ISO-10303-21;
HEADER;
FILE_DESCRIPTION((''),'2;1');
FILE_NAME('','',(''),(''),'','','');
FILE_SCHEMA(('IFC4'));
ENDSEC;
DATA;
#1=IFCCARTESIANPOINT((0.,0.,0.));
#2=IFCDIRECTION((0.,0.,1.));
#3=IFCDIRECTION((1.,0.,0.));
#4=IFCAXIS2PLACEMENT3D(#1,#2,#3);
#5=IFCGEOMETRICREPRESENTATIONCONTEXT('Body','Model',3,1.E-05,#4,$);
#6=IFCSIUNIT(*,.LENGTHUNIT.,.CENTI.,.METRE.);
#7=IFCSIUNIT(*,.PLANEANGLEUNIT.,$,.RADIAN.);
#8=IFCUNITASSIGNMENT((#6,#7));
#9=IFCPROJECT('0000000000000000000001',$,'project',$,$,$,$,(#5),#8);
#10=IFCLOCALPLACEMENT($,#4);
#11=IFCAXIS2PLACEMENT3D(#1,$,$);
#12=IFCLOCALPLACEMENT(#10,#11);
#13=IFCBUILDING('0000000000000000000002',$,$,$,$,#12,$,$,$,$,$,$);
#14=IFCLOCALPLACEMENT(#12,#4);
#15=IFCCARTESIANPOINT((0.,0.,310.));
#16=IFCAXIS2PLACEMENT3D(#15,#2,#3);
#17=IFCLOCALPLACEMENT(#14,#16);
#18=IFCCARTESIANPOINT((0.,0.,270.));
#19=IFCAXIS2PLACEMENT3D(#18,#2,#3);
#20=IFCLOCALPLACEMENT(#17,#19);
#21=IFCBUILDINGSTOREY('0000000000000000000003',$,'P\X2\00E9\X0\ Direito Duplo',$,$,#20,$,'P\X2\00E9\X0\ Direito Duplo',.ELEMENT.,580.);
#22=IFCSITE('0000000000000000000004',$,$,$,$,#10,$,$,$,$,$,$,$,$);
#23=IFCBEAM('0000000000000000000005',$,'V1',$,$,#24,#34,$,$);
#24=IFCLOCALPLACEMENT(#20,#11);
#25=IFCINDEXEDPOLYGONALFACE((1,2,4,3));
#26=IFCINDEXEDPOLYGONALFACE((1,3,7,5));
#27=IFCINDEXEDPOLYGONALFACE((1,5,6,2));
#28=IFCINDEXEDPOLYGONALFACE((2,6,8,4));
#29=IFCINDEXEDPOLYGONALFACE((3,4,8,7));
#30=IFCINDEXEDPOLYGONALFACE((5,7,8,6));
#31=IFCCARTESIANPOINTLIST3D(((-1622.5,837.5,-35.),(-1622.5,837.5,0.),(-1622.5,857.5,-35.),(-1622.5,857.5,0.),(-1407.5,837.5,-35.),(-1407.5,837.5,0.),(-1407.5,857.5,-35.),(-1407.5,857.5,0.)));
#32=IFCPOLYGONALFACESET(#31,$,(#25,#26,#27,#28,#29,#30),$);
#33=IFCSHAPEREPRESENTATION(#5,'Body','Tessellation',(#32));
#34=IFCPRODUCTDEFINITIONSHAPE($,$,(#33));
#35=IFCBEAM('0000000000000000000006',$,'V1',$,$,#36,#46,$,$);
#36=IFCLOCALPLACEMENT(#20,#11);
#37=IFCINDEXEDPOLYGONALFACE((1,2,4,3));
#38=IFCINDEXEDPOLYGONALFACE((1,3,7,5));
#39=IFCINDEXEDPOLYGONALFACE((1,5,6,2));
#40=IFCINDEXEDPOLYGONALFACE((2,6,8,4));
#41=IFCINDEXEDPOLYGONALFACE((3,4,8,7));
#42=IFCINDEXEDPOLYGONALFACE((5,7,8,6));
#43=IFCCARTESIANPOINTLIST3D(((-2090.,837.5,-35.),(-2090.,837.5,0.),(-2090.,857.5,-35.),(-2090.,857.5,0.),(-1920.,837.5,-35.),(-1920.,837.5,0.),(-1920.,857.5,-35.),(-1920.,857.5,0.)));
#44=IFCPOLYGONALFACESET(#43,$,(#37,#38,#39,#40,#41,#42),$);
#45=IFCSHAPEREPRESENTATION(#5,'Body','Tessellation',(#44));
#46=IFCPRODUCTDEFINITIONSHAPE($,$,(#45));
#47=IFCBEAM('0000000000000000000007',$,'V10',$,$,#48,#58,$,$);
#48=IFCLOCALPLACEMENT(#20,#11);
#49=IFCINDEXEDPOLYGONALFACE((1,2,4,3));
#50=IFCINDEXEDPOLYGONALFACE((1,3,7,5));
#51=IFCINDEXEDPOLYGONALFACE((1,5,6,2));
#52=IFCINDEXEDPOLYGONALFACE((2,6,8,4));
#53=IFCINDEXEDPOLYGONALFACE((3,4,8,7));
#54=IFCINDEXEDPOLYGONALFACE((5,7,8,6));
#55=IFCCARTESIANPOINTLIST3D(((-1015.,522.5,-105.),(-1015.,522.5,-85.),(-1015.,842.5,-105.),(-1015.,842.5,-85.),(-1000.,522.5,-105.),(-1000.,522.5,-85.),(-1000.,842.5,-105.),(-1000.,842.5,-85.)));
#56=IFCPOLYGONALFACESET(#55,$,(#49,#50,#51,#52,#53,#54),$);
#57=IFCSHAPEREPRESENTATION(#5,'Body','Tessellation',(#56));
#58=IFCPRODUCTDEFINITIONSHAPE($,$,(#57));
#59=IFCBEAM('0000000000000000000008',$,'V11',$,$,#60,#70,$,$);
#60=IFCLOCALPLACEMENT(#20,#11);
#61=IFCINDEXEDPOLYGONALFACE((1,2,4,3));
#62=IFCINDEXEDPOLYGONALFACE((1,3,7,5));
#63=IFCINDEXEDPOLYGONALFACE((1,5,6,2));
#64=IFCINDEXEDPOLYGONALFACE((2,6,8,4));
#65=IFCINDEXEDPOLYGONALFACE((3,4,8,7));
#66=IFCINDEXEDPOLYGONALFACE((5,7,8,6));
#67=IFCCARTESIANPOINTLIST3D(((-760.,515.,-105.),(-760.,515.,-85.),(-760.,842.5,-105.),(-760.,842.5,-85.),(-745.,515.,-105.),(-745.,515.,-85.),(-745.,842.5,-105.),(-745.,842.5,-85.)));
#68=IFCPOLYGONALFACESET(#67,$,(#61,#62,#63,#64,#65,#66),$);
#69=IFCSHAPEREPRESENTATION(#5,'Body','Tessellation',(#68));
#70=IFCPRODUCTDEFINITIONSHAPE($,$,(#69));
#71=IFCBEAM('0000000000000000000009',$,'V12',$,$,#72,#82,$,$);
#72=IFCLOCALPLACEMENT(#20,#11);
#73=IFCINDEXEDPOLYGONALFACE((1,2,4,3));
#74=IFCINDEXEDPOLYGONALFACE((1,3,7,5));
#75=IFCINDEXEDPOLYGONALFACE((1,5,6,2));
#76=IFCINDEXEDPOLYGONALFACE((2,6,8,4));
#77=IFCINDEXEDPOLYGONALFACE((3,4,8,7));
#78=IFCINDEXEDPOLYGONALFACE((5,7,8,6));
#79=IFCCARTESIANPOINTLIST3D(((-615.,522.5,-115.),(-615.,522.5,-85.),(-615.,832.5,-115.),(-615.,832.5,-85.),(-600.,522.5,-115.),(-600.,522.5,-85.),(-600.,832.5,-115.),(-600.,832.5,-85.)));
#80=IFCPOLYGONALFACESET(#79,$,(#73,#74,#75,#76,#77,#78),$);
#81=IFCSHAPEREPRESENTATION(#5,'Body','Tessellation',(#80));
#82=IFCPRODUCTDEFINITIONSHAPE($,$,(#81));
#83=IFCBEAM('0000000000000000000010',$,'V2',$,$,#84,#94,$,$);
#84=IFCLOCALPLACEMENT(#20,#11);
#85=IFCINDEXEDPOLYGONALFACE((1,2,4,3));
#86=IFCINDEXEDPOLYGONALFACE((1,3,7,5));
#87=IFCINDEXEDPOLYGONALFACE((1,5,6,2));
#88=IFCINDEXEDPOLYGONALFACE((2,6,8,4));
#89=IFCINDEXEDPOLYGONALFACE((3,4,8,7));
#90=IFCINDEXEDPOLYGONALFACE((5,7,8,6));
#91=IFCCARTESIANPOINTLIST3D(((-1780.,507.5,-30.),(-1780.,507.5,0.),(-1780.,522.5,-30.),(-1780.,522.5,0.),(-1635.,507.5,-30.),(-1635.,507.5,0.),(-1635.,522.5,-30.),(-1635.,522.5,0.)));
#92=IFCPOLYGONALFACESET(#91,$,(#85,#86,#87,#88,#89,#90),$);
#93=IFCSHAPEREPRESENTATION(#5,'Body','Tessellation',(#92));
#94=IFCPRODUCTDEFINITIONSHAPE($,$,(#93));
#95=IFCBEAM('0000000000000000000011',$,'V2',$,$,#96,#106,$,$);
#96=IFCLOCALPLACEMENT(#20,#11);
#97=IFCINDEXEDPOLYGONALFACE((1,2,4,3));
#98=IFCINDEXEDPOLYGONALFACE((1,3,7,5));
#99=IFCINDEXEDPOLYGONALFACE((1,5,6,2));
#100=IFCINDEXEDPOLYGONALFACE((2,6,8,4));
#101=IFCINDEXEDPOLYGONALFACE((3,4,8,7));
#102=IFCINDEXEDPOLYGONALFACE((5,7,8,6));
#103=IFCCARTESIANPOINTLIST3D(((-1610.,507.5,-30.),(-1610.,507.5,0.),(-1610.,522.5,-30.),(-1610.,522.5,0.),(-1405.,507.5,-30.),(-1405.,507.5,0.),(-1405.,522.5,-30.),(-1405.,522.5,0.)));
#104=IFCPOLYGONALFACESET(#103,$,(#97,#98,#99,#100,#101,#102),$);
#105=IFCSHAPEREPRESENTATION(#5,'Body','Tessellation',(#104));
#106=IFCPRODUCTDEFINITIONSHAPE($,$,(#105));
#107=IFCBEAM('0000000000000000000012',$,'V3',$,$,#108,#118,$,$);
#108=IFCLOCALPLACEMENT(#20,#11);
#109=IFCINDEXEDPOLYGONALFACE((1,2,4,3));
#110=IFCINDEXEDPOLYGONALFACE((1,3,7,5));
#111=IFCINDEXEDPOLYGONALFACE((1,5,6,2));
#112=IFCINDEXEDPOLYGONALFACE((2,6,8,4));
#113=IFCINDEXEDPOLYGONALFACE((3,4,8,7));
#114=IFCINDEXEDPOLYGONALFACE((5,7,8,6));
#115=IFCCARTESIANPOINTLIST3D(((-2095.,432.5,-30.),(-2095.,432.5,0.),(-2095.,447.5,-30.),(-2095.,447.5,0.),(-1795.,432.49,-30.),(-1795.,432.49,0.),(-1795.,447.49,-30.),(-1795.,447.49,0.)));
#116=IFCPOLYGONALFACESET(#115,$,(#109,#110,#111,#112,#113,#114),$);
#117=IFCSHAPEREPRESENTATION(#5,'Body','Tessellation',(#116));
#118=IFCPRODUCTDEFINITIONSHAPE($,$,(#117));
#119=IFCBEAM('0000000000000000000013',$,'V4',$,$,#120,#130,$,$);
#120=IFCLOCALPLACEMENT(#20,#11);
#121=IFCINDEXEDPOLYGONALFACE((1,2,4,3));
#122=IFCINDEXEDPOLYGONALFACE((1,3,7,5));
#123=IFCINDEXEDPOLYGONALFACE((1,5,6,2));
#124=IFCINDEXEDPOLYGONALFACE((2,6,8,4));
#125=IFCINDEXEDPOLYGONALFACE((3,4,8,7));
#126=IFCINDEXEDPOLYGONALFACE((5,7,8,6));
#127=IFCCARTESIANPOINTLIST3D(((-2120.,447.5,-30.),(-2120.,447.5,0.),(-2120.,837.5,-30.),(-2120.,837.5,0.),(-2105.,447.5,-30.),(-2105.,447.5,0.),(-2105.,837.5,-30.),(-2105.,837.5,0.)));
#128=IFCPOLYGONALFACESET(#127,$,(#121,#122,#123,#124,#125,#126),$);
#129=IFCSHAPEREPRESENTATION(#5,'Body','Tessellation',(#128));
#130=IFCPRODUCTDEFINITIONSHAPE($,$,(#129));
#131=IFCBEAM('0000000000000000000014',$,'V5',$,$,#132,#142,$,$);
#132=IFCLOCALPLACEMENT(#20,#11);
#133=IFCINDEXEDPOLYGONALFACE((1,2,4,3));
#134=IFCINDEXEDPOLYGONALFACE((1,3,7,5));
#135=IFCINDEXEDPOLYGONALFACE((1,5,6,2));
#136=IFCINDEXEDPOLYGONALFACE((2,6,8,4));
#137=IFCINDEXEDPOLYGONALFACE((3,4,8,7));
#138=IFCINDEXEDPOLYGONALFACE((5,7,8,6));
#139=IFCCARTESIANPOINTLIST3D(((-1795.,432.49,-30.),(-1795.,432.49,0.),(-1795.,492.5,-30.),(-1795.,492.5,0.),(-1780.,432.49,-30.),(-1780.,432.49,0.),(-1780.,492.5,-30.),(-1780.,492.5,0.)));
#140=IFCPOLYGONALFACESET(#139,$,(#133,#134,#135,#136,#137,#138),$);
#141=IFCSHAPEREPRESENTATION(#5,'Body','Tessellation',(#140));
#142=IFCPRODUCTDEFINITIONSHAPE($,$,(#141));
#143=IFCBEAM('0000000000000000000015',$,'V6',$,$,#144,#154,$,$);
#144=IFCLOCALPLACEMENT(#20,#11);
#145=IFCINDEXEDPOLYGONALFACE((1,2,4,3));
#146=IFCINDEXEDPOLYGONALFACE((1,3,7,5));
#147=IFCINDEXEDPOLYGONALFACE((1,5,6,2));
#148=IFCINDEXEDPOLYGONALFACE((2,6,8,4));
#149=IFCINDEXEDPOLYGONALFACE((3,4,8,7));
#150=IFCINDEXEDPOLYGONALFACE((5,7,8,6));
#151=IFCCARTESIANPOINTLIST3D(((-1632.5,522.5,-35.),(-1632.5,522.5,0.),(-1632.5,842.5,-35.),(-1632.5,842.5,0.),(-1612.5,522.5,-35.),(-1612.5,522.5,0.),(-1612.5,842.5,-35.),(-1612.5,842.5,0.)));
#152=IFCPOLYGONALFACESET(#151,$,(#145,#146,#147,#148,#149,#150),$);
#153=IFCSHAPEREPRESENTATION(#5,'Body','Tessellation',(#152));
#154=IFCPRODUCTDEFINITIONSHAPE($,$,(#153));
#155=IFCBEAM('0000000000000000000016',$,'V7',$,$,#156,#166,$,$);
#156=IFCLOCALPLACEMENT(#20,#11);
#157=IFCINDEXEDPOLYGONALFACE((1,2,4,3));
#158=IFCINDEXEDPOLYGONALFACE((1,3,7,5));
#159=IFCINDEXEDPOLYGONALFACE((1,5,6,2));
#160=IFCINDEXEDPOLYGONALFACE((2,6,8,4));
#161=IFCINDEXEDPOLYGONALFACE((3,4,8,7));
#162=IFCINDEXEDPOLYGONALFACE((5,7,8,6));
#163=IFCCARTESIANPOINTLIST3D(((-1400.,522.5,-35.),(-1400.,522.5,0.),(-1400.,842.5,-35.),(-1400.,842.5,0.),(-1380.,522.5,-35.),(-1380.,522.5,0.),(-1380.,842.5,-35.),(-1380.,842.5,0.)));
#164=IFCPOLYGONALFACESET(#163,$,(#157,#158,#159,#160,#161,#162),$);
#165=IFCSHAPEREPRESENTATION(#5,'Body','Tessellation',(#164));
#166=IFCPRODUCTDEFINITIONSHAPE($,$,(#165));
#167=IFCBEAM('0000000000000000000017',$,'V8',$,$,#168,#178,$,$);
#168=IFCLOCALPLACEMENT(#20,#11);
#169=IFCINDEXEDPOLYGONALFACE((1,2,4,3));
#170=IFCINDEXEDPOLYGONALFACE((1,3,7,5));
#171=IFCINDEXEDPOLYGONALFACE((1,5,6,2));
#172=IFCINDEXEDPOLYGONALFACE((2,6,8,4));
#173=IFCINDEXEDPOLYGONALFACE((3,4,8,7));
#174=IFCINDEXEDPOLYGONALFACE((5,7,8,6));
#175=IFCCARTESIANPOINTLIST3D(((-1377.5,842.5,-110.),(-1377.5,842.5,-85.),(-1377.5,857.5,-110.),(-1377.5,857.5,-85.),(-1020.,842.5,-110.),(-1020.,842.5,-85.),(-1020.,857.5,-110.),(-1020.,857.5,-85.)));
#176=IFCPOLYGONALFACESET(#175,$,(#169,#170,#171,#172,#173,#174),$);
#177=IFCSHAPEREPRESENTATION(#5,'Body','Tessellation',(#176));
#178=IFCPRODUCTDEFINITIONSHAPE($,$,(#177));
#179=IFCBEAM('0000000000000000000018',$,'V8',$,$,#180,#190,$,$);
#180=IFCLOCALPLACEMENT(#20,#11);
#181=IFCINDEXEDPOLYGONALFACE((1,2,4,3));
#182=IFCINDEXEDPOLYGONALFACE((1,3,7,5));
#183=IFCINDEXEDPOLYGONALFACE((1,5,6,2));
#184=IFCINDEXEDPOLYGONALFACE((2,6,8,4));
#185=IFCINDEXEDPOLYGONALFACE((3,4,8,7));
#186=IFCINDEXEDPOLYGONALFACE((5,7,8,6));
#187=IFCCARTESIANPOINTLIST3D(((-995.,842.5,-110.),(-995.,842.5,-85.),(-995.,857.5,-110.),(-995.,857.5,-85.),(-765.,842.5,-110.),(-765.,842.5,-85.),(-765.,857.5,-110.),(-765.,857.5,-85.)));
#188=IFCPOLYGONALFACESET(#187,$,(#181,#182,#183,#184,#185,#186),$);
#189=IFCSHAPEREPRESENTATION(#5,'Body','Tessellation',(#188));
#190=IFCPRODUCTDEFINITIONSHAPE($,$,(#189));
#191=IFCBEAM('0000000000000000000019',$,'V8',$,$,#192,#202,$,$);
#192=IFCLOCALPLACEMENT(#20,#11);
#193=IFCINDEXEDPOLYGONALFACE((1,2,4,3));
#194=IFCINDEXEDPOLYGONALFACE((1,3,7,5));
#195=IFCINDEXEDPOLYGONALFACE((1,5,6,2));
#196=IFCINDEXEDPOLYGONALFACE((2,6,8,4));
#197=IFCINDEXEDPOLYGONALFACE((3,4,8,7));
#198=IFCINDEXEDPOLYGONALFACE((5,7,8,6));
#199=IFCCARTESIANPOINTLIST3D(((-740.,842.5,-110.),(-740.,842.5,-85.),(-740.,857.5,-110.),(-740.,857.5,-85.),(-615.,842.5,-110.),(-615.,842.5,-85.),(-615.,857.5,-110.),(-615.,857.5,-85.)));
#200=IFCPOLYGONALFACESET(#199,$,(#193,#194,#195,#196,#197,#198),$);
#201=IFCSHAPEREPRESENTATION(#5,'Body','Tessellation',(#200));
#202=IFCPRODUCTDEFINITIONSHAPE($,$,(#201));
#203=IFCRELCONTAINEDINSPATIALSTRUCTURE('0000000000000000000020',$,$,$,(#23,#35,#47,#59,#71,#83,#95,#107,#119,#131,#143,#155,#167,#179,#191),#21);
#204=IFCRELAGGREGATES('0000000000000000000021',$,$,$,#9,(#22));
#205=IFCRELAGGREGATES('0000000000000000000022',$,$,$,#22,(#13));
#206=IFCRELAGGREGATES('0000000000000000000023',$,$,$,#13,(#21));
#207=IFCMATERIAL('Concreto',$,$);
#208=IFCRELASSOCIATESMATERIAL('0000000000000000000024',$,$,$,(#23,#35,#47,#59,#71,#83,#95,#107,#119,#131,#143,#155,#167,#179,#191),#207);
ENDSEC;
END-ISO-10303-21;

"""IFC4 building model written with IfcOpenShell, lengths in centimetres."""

from ifc_helpers import new_model, si_unit, frame, origin, origin_with_axes, origin_2d_with_axis, place, context, project, spatial, rectangle, extrude, material, element, save


model = new_model("IFC4")

# Units and contexts
model_context = context("Model", 3, precision=1e-05, world=origin_with_axes(), identifier="Body")
ifc_project = project(units=[si_unit("LENGTHUNIT", "METRE", prefix="CENTI"), si_unit("PLANEANGLEUNIT", "RADIAN")], contexts=[model_context])

# Site, building, storey
site_placement = place(None, origin_with_axes())
site = spatial("IfcSite", under=ifc_project, at=site_placement)
building_placement = place(site_placement, origin())
building = spatial("IfcBuilding", under=site, at=building_placement)
placement_1 = place(building_placement, origin_with_axes())
placement_2 = place(placement_1, frame((0.0, 0.0, 310.0), z_axis=(0.0, 0.0, 1.0), x_axis=(1.0, 0.0, 0.0)))
storey_placement = place(placement_2, frame((0.0, 0.0, 270.0), z_axis=(0.0, 0.0, 1.0), x_axis=(1.0, 0.0, 0.0)))
storey = spatial("IfcBuildingStorey", under=building, at=storey_placement, Name="Pé Direito Duplo", LongName="Pé Direito Duplo", CompositionType="ELEMENT", Elevation=580.0)

# Shared definitions
ifc_material = material(Name="Concreto")

# Beams
beam_1_placement = place(storey_placement, frame((-1515.0, 847.5, 0.0), z_axis=(0.0, 0.0, 1.0), x_axis=(1.0, 0.0, 0.0)))
element("IfcBeam", 1, at=beam_1_placement, inside=storey, material=ifc_material, Name="V1", context=model_context, shape_type="SolidModel", body=[
    extrude(rectangle(XDim=20.0, YDim=35.0, at=origin_2d_with_axis()), frame((-107.5, 0.0, -17.5), z_axis=(1.0, 0.0, 0.0), x_axis=(0.0, -1.0, 0.0)), (0.0, 0.0, 1.0), 215.0),
])
beam_2_placement = place(storey_placement, frame((-2005.0, 847.5, 0.0), z_axis=(0.0, 0.0, 1.0), x_axis=(1.0, 0.0, 0.0)))
element("IfcBeam", 2, at=beam_2_placement, inside=storey, material=ifc_material, Name="V1", context=model_context, shape_type="SolidModel", body=[
    extrude(rectangle(XDim=20.0, YDim=35.0, at=origin_2d_with_axis()), frame((-85.0, 0.0, -17.5), z_axis=(1.0, 0.0, 0.0), x_axis=(0.0, -1.0, 0.0)), (0.0, 0.0, 1.0), 170.0),
])
beam_3_placement = place(storey_placement, frame((-1007.5, 682.5, -85.0), z_axis=(0.0, 0.0, 1.0), x_axis=(1.0, 0.0, 0.0)))
element("IfcBeam", 3, at=beam_3_placement, inside=storey, material=ifc_material, Name="V10", context=model_context, shape_type="SolidModel", body=[
    extrude(rectangle(XDim=15.0, YDim=20.0, at=origin_2d_with_axis()), frame((0.0, -160.0, -10.0), z_axis=(0.0, 1.0, 0.0), x_axis=(-1.0, 0.0, 0.0)), (0.0, 0.0, 1.0), 320.0),
])
beam_4_placement = place(storey_placement, frame((-752.5, 678.75, -85.0), z_axis=(0.0, 0.0, 1.0), x_axis=(1.0, 0.0, 0.0)))
element("IfcBeam", 4, at=beam_4_placement, inside=storey, material=ifc_material, Name="V11", context=model_context, shape_type="SolidModel", body=[
    extrude(rectangle(XDim=15.0, YDim=20.0, at=origin_2d_with_axis()), frame((0.0, -163.75, -10.0), z_axis=(0.0, 1.0, 0.0), x_axis=(-1.0, 0.0, 0.0)), (0.0, 0.0, 1.0), 327.5),
])
beam_5_placement = place(storey_placement, frame((-607.5, 677.5, -85.0), z_axis=(0.0, 0.0, 1.0), x_axis=(1.0, 0.0, 0.0)))
element("IfcBeam", 5, at=beam_5_placement, inside=storey, material=ifc_material, Name="V12", context=model_context, shape_type="SolidModel", body=[
    extrude(rectangle(XDim=15.0, YDim=30.0, at=origin_2d_with_axis()), frame((0.0, -155.0, -15.0), z_axis=(0.0, 1.0, 0.0), x_axis=(-1.0, 0.0, 0.0)), (0.0, 0.0, 1.0), 310.0),
])
beam_6_placement = place(storey_placement, frame((-1707.5, 515.0, 0.0), z_axis=(0.0, 0.0, 1.0), x_axis=(1.0, 0.0, 0.0)))
element("IfcBeam", 6, at=beam_6_placement, inside=storey, material=ifc_material, Name="V2", context=model_context, shape_type="SolidModel", body=[
    extrude(rectangle(XDim=15.0, YDim=30.0, at=origin_2d_with_axis()), frame((-72.5, 0.0, -15.0), z_axis=(1.0, 0.0, 0.0), x_axis=(0.0, -1.0, 0.0)), (0.0, 0.0, 1.0), 145.0),
])
beam_7_placement = place(storey_placement, frame((-1507.5, 515.0, 0.0), z_axis=(0.0, 0.0, 1.0), x_axis=(1.0, 0.0, 0.0)))
element("IfcBeam", 7, at=beam_7_placement, inside=storey, material=ifc_material, Name="V2", context=model_context, shape_type="SolidModel", body=[
    extrude(rectangle(XDim=15.0, YDim=30.0, at=origin_2d_with_axis()), frame((-102.5, 0.0, -15.0), z_axis=(1.0, 0.0, 0.0), x_axis=(0.0, -1.0, 0.0)), (0.0, 0.0, 1.0), 205.0),
])
beam_8_placement = place(storey_placement, frame((-1945.0, 440.0, 0.0), z_axis=(0.0, 0.0, 1.0), x_axis=(1.0, 0.0, 0.0)))
element("IfcBeam", 8, at=beam_8_placement, inside=storey, material=ifc_material, Name="V3", context=model_context, shape_type="SolidModel", body=[
    extrude(rectangle(XDim=15.0, YDim=30.0, at=origin_2d_with_axis()), frame((-150.0, 0.0, -15.0), z_axis=(1.0, -0.000033, 0.0), x_axis=(-0.000033, -1.0, 0.0)), (0.0, 0.0, 1.0), 300.0),
])
beam_9_placement = place(storey_placement, frame((-2112.5, 642.5, 0.0), z_axis=(0.0, 0.0, 1.0), x_axis=(1.0, 0.0, 0.0)))
element("IfcBeam", 9, at=beam_9_placement, inside=storey, material=ifc_material, Name="V4", context=model_context, shape_type="SolidModel", body=[
    extrude(rectangle(XDim=15.0, YDim=30.0, at=origin_2d_with_axis()), frame((0.0, -195.0, -15.0), z_axis=(0.0, 1.0, 0.0), x_axis=(-1.0, 0.0, 0.0)), (0.0, 0.0, 1.0), 390.0),
])
beam_10_placement = place(storey_placement, frame((-1787.5, 462.5, 0.0), z_axis=(0.0, 0.0, 1.0), x_axis=(1.0, 0.0, 0.0)))
element("IfcBeam", 10, at=beam_10_placement, inside=storey, material=ifc_material, Name="V5", context=model_context, shape_type="SolidModel", body=[
    extrude(rectangle(XDim=15.0, YDim=30.0, at=origin_2d_with_axis()), frame((0.0, -30.0, -15.0), z_axis=(0.0, 1.0, 0.0), x_axis=(-1.0, 0.0, 0.0)), (0.0, 0.0, 1.0), 60.01),
])
for number, where, z_axis, x_axis, name in (
    (11, (-1622.5, 682.5, 0.0), (0.0, 0.0, 1.0), (1.0, 0.0, 0.0), "V6"),
    (12, (-1390.0, 682.5, 0.0), (0.0, 0.0, 1.0), (1.0, 0.0, 0.0), "V7"),
):
    element("IfcBeam", number, at=place(storey_placement, frame(where, z_axis=z_axis, x_axis=x_axis)), inside=storey, material=ifc_material, Name=name, context=model_context, shape_type="SolidModel", body=[
        extrude(rectangle(XDim=20.0, YDim=35.0, at=origin_2d_with_axis()), frame((0.0, -160.0, -17.5), z_axis=(0.0, 1.0, 0.0), x_axis=(-1.0, 0.0, 0.0)), (0.0, 0.0, 1.0), 320.0),
    ])
beam_11_placement = place(storey_placement, frame((-1198.75, 850.0, -85.0), z_axis=(0.0, 0.0, 1.0), x_axis=(1.0, 0.0, 0.0)))
element("IfcBeam", 13, at=beam_11_placement, inside=storey, material=ifc_material, Name="V8", context=model_context, shape_type="SolidModel", body=[
    extrude(rectangle(XDim=15.0, YDim=25.0, at=origin_2d_with_axis()), frame((-178.75, 0.0, -12.5), z_axis=(1.0, 0.0, 0.0), x_axis=(0.0, -1.0, 0.0)), (0.0, 0.0, 1.0), 357.5),
])
beam_12_placement = place(storey_placement, frame((-880.0, 850.0, -85.0), z_axis=(0.0, 0.0, 1.0), x_axis=(1.0, 0.0, 0.0)))
element("IfcBeam", 14, at=beam_12_placement, inside=storey, material=ifc_material, Name="V8", context=model_context, shape_type="SolidModel", body=[
    extrude(rectangle(XDim=15.0, YDim=25.0, at=origin_2d_with_axis()), frame((-115.0, 0.0, -12.5), z_axis=(1.0, 0.0, 0.0), x_axis=(0.0, 1.0, 0.0)), (0.0, 0.0, 1.0), 230.0),
])
beam_13_placement = place(storey_placement, frame((-677.5, 850.0, -85.0), z_axis=(0.0, 0.0, 1.0), x_axis=(1.0, 0.0, 0.0)))
element("IfcBeam", 15, at=beam_13_placement, inside=storey, material=ifc_material, Name="V8", context=model_context, shape_type="SolidModel", body=[
    extrude(rectangle(XDim=15.0, YDim=25.0, at=origin_2d_with_axis()), frame((-62.5, 0.0, -12.5), z_axis=(1.0, 0.0, 0.0), x_axis=(0.0, 1.0, 0.0)), (0.0, 0.0, 1.0), 125.0),
])

save(model, "model.ifc")
